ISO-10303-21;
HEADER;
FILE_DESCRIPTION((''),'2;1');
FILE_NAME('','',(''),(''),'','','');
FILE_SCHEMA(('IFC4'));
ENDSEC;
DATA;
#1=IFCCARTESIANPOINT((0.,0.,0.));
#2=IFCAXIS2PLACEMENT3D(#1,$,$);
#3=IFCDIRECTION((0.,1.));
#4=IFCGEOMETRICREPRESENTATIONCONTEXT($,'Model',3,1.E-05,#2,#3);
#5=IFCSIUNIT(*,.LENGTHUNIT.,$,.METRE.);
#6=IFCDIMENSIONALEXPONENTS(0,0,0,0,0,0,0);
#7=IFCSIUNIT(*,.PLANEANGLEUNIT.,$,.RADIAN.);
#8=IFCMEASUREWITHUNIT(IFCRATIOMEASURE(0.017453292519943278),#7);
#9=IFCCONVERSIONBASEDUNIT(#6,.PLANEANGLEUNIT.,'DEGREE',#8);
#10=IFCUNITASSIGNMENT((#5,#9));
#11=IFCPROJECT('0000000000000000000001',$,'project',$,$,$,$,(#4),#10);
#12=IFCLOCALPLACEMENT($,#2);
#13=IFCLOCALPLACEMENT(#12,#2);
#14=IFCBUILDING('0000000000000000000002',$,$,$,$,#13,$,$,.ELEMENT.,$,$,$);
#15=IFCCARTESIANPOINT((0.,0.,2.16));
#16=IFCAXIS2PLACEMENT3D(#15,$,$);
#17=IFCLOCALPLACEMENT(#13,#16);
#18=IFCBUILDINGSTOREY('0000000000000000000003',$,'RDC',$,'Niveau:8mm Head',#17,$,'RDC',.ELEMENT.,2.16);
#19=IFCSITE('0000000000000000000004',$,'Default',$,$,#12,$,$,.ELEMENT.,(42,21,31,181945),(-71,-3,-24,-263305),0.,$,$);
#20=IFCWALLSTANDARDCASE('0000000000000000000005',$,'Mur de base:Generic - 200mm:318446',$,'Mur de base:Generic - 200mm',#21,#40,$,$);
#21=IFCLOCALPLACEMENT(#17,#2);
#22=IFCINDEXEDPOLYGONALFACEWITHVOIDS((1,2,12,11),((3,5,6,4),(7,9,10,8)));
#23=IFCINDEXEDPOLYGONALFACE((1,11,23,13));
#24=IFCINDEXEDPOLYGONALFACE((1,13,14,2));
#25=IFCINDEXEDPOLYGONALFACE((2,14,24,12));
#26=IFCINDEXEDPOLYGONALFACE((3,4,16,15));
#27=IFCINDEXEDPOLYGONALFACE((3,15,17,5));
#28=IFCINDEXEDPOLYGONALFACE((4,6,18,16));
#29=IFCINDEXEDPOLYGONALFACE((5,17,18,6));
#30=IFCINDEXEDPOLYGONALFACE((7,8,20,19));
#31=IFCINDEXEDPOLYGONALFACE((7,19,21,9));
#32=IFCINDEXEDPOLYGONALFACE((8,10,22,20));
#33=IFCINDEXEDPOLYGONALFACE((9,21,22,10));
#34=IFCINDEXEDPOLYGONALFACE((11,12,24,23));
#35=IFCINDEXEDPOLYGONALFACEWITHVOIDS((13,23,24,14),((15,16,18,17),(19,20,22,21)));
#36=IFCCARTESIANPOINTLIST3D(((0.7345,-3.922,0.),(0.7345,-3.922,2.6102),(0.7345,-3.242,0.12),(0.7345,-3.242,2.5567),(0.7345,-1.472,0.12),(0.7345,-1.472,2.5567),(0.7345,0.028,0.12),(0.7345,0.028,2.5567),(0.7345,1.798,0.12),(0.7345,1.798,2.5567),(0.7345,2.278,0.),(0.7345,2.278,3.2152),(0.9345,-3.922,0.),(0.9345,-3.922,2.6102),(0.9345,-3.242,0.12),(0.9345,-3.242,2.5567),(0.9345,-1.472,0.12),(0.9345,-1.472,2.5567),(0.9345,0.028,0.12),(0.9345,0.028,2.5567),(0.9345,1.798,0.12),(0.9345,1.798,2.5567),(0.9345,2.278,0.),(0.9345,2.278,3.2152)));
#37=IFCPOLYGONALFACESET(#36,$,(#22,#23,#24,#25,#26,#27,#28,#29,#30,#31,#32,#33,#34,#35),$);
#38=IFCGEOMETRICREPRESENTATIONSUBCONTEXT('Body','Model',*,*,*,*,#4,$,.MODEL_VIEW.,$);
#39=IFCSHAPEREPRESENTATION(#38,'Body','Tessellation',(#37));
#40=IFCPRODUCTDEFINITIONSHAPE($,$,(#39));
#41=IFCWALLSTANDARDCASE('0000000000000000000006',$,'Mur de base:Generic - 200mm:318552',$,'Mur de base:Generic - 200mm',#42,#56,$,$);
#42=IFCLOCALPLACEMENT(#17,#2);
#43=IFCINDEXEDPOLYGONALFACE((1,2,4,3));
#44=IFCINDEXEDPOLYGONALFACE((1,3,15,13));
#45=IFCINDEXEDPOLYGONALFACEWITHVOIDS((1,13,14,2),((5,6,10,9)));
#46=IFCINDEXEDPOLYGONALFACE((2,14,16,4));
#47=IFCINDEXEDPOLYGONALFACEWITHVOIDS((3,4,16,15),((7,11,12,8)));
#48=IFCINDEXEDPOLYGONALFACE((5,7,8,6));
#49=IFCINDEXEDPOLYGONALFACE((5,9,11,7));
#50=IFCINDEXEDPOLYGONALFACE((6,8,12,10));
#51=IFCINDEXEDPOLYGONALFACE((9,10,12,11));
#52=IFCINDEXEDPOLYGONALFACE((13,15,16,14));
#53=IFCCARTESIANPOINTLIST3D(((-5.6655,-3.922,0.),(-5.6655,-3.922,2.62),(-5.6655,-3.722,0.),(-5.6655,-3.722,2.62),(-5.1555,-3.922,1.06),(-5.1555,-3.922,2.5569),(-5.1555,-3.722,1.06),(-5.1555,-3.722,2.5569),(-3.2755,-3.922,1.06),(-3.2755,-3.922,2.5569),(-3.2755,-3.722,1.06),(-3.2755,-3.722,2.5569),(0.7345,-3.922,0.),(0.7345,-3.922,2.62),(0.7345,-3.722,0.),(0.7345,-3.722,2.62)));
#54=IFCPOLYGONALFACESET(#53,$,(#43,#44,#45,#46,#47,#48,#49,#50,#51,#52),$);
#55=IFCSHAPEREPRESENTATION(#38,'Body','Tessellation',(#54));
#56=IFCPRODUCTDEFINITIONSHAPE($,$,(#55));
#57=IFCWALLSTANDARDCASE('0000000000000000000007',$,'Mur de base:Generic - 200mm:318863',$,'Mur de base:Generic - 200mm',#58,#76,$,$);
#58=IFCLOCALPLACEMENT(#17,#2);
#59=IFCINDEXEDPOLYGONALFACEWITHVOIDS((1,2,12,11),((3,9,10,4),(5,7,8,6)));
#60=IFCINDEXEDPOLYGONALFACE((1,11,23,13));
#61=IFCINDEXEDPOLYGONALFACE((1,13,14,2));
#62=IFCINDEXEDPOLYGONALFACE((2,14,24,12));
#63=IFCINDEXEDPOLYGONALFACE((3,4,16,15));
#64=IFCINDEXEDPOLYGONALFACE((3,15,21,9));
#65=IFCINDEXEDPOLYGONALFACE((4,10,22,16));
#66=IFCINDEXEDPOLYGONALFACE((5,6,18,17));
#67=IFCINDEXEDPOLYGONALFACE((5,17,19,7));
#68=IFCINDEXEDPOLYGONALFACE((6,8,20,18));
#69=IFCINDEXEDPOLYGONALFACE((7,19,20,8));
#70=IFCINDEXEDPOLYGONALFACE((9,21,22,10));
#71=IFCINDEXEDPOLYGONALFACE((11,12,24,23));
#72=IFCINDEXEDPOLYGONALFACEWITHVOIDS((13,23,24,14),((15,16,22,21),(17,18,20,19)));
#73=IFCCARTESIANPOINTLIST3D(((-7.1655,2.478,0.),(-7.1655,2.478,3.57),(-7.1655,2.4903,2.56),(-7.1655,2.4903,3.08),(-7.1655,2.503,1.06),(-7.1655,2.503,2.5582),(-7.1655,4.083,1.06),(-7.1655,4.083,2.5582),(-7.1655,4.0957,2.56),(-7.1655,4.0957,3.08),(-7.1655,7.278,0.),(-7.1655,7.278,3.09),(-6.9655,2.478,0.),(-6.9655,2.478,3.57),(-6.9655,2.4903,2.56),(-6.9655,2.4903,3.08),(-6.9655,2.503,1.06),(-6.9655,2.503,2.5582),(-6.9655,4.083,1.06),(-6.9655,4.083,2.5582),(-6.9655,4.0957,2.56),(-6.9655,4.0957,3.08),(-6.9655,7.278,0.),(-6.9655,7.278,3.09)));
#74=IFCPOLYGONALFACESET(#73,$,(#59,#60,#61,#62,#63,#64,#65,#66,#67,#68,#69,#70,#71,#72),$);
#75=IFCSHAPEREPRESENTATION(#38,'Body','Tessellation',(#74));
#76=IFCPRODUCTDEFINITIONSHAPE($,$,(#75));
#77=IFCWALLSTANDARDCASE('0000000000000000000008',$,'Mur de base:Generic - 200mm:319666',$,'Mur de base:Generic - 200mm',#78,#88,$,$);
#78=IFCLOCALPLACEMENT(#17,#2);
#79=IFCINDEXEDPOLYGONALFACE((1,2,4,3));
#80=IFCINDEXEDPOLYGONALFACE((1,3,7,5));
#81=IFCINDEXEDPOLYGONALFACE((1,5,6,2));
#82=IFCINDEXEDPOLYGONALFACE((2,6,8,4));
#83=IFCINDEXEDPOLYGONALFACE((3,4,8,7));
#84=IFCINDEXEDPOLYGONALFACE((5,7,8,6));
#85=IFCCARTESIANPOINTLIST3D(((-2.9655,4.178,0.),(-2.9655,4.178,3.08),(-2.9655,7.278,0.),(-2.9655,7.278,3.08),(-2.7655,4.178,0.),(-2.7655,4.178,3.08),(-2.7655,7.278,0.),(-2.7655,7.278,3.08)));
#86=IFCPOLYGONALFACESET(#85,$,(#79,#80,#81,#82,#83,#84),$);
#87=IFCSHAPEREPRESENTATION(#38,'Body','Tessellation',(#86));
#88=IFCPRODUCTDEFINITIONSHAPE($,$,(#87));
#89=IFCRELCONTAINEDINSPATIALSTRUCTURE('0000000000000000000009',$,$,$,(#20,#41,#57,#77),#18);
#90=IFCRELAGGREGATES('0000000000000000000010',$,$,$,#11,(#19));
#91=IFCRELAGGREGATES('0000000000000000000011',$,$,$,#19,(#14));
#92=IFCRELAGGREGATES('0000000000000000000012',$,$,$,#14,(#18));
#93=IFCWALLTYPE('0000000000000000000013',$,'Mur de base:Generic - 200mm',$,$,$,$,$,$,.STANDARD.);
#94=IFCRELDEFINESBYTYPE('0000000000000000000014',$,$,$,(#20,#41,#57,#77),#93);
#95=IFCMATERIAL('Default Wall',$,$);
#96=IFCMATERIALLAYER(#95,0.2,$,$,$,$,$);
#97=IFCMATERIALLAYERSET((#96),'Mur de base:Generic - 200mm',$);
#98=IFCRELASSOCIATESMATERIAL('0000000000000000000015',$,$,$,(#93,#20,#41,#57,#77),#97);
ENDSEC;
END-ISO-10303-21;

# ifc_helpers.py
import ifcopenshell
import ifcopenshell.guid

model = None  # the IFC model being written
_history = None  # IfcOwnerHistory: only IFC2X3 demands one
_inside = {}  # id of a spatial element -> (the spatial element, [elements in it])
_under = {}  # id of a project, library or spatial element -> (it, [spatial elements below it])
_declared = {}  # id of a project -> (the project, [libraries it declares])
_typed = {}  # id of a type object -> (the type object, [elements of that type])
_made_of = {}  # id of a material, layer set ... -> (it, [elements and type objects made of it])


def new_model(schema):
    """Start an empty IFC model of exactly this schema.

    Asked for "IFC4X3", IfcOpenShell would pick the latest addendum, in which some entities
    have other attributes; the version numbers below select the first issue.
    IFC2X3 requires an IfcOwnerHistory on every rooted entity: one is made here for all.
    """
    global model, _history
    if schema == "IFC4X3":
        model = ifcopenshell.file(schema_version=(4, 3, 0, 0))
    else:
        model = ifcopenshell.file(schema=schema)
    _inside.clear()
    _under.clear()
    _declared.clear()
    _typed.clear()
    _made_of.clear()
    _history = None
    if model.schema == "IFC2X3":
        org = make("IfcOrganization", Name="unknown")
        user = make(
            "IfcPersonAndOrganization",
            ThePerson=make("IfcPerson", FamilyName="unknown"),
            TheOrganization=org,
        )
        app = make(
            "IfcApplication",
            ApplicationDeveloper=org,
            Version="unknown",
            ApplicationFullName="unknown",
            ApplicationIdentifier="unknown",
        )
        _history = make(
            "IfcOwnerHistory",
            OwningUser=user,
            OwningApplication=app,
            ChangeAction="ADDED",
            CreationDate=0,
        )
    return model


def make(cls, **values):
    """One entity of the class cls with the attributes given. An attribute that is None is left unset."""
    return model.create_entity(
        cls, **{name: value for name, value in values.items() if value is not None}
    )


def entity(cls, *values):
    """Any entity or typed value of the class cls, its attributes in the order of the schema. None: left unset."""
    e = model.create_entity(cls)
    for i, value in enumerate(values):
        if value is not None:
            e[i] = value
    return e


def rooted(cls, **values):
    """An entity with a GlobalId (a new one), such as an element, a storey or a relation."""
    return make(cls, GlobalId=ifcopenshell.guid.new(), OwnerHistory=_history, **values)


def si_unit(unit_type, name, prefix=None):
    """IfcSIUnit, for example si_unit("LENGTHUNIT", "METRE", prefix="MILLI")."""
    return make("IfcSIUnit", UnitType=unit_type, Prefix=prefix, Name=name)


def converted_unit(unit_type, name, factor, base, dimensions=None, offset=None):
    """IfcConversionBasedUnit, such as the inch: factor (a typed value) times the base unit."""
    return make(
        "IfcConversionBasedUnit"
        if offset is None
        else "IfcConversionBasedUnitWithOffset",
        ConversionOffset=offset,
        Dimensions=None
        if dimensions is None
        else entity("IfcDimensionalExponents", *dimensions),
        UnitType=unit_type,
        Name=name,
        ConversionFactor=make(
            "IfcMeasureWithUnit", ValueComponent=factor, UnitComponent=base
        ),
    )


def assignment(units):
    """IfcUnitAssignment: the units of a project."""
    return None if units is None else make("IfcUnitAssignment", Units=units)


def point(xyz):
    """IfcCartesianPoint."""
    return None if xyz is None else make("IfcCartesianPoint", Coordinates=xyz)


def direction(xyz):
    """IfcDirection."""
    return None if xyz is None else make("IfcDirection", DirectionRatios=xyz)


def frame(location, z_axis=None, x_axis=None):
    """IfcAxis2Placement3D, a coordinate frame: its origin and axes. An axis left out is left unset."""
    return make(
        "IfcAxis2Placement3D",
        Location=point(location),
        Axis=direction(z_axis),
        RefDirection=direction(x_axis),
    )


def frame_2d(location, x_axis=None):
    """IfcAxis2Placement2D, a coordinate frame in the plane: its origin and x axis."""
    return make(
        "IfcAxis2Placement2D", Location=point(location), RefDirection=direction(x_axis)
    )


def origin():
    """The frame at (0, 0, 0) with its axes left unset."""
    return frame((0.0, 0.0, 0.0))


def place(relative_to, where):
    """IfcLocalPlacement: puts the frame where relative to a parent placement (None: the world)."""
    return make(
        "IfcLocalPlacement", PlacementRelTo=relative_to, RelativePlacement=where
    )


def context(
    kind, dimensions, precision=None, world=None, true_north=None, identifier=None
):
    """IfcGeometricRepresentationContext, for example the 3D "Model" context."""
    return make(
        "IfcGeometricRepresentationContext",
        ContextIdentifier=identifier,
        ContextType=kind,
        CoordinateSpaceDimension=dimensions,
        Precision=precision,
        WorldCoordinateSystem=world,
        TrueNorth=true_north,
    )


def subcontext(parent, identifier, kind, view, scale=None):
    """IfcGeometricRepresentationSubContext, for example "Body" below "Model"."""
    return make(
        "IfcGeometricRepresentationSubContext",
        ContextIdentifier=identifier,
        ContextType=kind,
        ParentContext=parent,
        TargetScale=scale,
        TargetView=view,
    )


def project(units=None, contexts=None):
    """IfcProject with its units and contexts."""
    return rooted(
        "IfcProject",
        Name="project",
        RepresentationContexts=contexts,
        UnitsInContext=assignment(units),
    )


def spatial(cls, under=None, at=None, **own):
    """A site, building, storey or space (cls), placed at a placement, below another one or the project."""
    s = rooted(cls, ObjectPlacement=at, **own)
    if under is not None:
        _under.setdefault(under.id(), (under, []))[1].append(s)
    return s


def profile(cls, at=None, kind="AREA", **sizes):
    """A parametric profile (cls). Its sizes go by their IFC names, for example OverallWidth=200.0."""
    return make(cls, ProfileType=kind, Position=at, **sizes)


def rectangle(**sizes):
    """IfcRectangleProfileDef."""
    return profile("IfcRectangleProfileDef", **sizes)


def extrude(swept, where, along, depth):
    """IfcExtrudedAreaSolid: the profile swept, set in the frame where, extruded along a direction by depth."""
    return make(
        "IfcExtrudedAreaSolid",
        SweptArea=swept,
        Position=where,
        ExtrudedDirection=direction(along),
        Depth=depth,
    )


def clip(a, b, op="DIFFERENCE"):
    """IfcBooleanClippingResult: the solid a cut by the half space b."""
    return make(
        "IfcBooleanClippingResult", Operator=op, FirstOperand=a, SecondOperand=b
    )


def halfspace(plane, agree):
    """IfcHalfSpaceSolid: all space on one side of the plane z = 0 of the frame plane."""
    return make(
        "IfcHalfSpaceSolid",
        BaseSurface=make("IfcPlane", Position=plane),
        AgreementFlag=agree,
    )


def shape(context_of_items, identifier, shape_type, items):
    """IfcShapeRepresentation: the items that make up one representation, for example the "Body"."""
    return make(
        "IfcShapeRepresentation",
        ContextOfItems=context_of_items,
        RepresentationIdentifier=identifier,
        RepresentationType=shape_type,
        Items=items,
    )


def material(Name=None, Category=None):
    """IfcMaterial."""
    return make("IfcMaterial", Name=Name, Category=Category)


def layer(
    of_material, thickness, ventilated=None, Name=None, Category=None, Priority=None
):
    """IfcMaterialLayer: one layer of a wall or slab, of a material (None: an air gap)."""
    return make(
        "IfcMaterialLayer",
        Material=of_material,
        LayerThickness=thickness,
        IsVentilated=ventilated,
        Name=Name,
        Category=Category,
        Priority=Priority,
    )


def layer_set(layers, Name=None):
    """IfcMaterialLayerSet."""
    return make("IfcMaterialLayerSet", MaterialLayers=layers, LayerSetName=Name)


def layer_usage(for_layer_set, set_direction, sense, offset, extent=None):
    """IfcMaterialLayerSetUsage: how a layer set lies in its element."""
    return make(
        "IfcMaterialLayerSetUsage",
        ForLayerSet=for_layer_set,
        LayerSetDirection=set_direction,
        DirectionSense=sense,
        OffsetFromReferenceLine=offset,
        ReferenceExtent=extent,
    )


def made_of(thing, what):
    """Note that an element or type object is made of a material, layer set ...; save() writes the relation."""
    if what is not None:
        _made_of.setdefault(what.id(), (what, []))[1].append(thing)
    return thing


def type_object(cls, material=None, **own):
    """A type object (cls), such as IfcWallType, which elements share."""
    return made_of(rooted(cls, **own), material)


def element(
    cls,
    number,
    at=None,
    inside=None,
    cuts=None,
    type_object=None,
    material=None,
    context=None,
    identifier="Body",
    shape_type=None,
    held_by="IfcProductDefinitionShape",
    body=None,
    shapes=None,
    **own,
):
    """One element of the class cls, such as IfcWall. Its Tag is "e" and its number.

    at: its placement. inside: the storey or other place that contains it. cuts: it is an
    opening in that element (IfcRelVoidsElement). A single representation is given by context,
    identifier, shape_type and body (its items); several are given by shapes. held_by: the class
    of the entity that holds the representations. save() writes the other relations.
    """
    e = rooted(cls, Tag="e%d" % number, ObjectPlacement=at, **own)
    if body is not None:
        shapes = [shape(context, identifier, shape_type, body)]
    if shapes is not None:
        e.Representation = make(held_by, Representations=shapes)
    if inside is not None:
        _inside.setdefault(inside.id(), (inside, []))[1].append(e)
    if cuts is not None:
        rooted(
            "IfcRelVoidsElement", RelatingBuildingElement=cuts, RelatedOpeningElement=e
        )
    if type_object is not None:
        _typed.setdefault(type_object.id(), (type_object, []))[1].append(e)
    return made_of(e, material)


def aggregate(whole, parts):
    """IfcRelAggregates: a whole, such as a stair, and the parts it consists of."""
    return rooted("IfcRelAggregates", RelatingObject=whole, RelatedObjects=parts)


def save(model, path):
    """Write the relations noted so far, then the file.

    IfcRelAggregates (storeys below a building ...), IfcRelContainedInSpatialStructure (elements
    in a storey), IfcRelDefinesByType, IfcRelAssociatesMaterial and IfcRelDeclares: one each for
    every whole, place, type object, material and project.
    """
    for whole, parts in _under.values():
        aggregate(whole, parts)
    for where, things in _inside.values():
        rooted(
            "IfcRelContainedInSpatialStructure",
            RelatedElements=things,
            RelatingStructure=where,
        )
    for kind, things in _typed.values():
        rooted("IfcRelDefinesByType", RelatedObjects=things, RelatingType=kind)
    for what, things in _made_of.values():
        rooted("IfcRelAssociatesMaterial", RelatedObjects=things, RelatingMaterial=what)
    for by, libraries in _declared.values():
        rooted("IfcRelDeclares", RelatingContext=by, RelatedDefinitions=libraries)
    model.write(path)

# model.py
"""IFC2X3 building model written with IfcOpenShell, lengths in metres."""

from ifc_helpers import new_model, entity, si_unit, converted_unit, direction, frame, frame_2d, origin, place, context, subcontext, project, spatial, rectangle, extrude, clip, halfspace, material, layer, layer_set, layer_usage, type_object, element, save


model = new_model("IFC2X3")

# Units and contexts
model_context = context("Model", 3, precision=1e-05, world=origin(), true_north=direction((0.0, 1.0)))
body_context = subcontext(model_context, "Body", "Model", "MODEL_VIEW")
ifc_project = project(units=[si_unit("LENGTHUNIT", "METRE"), converted_unit("PLANEANGLEUNIT", "DEGREE", entity("IfcRatioMeasure", 0.017453292519943278), si_unit("PLANEANGLEUNIT", "RADIAN"), dimensions=[0, 0, 0, 0, 0, 0, 0])], contexts=[model_context])

# Site, building, storey
site_placement = place(None, origin())
site = spatial("IfcSite", under=ifc_project, at=site_placement, Name="Default", CompositionType="ELEMENT", RefLatitude=(42, 21, 31, 181945), RefLongitude=(-71, -3, -24, -263305), RefElevation=0.0)
building_placement = place(site_placement, origin())
building = spatial("IfcBuilding", under=site, at=building_placement, CompositionType="ELEMENT")
storey_placement = place(building_placement, frame((0.0, 0.0, 2.16)))
storey = spatial("IfcBuildingStorey", under=building, at=storey_placement, Name="RDC", ObjectType="Niveau:8mm Head", LongName="RDC", CompositionType="ELEMENT", Elevation=2.16)

# Wall, openings
ifc_material_1 = material(Name="Default Wall")
ifc_layer_1 = layer(ifc_material_1, 0.2)
ifc_layer_set_1 = layer_set([ifc_layer_1], Name="Mur de base:Generic - 200mm")
ifc_layer_usage_1 = layer_usage(ifc_layer_set_1, "AXIS2", "NEGATIVE", 0.1)
wall_type = type_object("IfcWallType", Name="Mur de base:Generic - 200mm", PredefinedType="STANDARD", material=ifc_layer_set_1)
wall_1_placement = place(storey_placement, frame((0.8345, 2.278, 0.0), z_axis=(0.0, 0.0, 1.0), x_axis=(0.0, -1.0, 0.0)))
wall_1 = element("IfcWallStandardCase", 1, at=wall_1_placement, inside=storey, type_object=wall_type, material=ifc_layer_usage_1, Name="Mur de base:Generic - 200mm:318446", ObjectType="Mur de base:Generic - 200mm", context=body_context, shape_type="Clipping", body=[
    clip(extrude(rectangle(XDim=6.2, YDim=0.2, at=frame_2d((3.1, 0.0), x_axis=(-1.0, 0.0))), origin(), (0.0, 0.0, 1.0), 3.2152), halfspace(frame((0.0, -0.1, 3.2152), z_axis=(0.097119, 0.0, 0.995273), x_axis=(0.0, 1.0, 0.0)), False)),
])
opening_1_placement = place(wall_1_placement, origin())
element("IfcOpeningElement", 2, at=opening_1_placement, cuts=wall_1, ObjectType="Opening", context=body_context, shape_type="SweptSolid", body=[
    extrude(rectangle(XDim=2.4367, YDim=1.77, at=frame_2d((0.0, 0.0), x_axis=(1.0, 0.0))), frame((1.365, -0.1, 1.3383), z_axis=(0.0, 1.0, 0.0), x_axis=(0.0, 0.0, -1.0)), (0.0, 0.0, 1.0), 0.2),
])
opening_2_placement = place(wall_1_placement, origin())
element("IfcOpeningElement", 3, at=opening_2_placement, cuts=wall_1, ObjectType="Opening", context=body_context, shape_type="SweptSolid", body=[
    extrude(rectangle(XDim=2.4367, YDim=1.77, at=frame_2d((0.0, 0.0), x_axis=(1.0, 0.0))), frame((4.635, -0.1, 1.3383), z_axis=(0.0, 1.0, 0.0), x_axis=(0.0, 0.0, -1.0)), (0.0, 0.0, 1.0), 0.2),
])

# Wall, opening
wall_2_placement = place(storey_placement, frame((0.7345, -3.822, 0.0), z_axis=(0.0, 0.0, 1.0), x_axis=(-1.0, 0.0, 0.0)))
wall_2 = element("IfcWallStandardCase", 4, at=wall_2_placement, inside=storey, type_object=wall_type, material=ifc_layer_usage_1, Name="Mur de base:Generic - 200mm:318552", ObjectType="Mur de base:Generic - 200mm", context=body_context, shape_type="SweptSolid", body=[
    extrude(rectangle(XDim=6.4, YDim=0.2, at=frame_2d((3.2, 0.0), x_axis=(-1.0, 0.0))), origin(), (0.0, 0.0, 1.0), 2.62),
])
opening_3_placement = place(wall_2_placement, origin())
element("IfcOpeningElement", 5, at=opening_3_placement, cuts=wall_2, ObjectType="Opening", context=body_context, shape_type="SweptSolid", body=[
    extrude(rectangle(XDim=1.4969, YDim=1.88, at=frame_2d((0.0, 0.0), x_axis=(1.0, 0.0))), frame((4.95, -0.1, 1.8084), z_axis=(0.0, 1.0, 0.0), x_axis=(0.0, 0.0, -1.0)), (0.0, 0.0, 1.0), 0.2),
])

# Wall, openings
wall_3_placement = place(storey_placement, frame((-7.0655, 2.478, 0.0), z_axis=(0.0, 0.0, 1.0), x_axis=(0.0, 1.0, 0.0)))
wall_3 = element("IfcWallStandardCase", 6, at=wall_3_placement, inside=storey, type_object=wall_type, material=ifc_layer_usage_1, Name="Mur de base:Generic - 200mm:318863", ObjectType="Mur de base:Generic - 200mm", context=body_context, shape_type="Clipping", body=[
    clip(extrude(rectangle(XDim=4.8, YDim=0.2, at=frame_2d((2.4, 0.0), x_axis=(-1.0, 0.0))), origin(), (0.0, 0.0, 1.0), 3.57), halfspace(frame((0.0, -0.1, 3.57), z_axis=(0.099504, 0.0, 0.995037), x_axis=(0.0, 1.0, 0.0)), False)),
])
opening_4_placement = place(storey_placement, frame((-7.0655, 2.478, 0.0), z_axis=(0.0, 0.0, 1.0), x_axis=(0.0, 1.0, 0.0)))
element("IfcOpeningElement", 7, at=opening_4_placement, cuts=wall_3, ObjectType="Opening", context=body_context, shape_type="SweptSolid", body=[
    extrude(rectangle(XDim=0.2, YDim=1.6054, at=frame_2d((0.0, 0.0), x_axis=(1.0, 0.0))), frame((0.815, 0.0, 2.56), z_axis=(0.0, 0.0, 1.0), x_axis=(0.0, 1.0, 0.0)), (0.0, 0.0, 1.0), 0.52),
])
opening_5_placement = place(wall_3_placement, origin())
element("IfcOpeningElement", 8, at=opening_5_placement, cuts=wall_3, ObjectType="Opening", context=body_context, shape_type="SweptSolid", body=[
    extrude(rectangle(XDim=1.4982, YDim=1.58, at=frame_2d((0.0, 0.0), x_axis=(1.0, 0.0))), frame((0.815, -0.1, 1.8091), z_axis=(0.0, 1.0, 0.0), x_axis=(0.0, 0.0, -1.0)), (0.0, 0.0, 1.0), 0.2),
])

# Wall
wall_4_placement = place(storey_placement, frame((-2.8655, 7.278, 0.0), z_axis=(0.0, 0.0, 1.0), x_axis=(0.0, -1.0, 0.0)))
element("IfcWallStandardCase", 9, at=wall_4_placement, inside=storey, type_object=wall_type, material=ifc_layer_usage_1, Name="Mur de base:Generic - 200mm:319666", ObjectType="Mur de base:Generic - 200mm", context=body_context, shape_type="SweptSolid", body=[
    extrude(rectangle(XDim=3.1, YDim=0.2, at=frame_2d((1.55, 0.0), x_axis=(-1.0, 0.0))), origin(), (0.0, 0.0, 1.0), 3.08),
])

save(model, "model.ifc")
